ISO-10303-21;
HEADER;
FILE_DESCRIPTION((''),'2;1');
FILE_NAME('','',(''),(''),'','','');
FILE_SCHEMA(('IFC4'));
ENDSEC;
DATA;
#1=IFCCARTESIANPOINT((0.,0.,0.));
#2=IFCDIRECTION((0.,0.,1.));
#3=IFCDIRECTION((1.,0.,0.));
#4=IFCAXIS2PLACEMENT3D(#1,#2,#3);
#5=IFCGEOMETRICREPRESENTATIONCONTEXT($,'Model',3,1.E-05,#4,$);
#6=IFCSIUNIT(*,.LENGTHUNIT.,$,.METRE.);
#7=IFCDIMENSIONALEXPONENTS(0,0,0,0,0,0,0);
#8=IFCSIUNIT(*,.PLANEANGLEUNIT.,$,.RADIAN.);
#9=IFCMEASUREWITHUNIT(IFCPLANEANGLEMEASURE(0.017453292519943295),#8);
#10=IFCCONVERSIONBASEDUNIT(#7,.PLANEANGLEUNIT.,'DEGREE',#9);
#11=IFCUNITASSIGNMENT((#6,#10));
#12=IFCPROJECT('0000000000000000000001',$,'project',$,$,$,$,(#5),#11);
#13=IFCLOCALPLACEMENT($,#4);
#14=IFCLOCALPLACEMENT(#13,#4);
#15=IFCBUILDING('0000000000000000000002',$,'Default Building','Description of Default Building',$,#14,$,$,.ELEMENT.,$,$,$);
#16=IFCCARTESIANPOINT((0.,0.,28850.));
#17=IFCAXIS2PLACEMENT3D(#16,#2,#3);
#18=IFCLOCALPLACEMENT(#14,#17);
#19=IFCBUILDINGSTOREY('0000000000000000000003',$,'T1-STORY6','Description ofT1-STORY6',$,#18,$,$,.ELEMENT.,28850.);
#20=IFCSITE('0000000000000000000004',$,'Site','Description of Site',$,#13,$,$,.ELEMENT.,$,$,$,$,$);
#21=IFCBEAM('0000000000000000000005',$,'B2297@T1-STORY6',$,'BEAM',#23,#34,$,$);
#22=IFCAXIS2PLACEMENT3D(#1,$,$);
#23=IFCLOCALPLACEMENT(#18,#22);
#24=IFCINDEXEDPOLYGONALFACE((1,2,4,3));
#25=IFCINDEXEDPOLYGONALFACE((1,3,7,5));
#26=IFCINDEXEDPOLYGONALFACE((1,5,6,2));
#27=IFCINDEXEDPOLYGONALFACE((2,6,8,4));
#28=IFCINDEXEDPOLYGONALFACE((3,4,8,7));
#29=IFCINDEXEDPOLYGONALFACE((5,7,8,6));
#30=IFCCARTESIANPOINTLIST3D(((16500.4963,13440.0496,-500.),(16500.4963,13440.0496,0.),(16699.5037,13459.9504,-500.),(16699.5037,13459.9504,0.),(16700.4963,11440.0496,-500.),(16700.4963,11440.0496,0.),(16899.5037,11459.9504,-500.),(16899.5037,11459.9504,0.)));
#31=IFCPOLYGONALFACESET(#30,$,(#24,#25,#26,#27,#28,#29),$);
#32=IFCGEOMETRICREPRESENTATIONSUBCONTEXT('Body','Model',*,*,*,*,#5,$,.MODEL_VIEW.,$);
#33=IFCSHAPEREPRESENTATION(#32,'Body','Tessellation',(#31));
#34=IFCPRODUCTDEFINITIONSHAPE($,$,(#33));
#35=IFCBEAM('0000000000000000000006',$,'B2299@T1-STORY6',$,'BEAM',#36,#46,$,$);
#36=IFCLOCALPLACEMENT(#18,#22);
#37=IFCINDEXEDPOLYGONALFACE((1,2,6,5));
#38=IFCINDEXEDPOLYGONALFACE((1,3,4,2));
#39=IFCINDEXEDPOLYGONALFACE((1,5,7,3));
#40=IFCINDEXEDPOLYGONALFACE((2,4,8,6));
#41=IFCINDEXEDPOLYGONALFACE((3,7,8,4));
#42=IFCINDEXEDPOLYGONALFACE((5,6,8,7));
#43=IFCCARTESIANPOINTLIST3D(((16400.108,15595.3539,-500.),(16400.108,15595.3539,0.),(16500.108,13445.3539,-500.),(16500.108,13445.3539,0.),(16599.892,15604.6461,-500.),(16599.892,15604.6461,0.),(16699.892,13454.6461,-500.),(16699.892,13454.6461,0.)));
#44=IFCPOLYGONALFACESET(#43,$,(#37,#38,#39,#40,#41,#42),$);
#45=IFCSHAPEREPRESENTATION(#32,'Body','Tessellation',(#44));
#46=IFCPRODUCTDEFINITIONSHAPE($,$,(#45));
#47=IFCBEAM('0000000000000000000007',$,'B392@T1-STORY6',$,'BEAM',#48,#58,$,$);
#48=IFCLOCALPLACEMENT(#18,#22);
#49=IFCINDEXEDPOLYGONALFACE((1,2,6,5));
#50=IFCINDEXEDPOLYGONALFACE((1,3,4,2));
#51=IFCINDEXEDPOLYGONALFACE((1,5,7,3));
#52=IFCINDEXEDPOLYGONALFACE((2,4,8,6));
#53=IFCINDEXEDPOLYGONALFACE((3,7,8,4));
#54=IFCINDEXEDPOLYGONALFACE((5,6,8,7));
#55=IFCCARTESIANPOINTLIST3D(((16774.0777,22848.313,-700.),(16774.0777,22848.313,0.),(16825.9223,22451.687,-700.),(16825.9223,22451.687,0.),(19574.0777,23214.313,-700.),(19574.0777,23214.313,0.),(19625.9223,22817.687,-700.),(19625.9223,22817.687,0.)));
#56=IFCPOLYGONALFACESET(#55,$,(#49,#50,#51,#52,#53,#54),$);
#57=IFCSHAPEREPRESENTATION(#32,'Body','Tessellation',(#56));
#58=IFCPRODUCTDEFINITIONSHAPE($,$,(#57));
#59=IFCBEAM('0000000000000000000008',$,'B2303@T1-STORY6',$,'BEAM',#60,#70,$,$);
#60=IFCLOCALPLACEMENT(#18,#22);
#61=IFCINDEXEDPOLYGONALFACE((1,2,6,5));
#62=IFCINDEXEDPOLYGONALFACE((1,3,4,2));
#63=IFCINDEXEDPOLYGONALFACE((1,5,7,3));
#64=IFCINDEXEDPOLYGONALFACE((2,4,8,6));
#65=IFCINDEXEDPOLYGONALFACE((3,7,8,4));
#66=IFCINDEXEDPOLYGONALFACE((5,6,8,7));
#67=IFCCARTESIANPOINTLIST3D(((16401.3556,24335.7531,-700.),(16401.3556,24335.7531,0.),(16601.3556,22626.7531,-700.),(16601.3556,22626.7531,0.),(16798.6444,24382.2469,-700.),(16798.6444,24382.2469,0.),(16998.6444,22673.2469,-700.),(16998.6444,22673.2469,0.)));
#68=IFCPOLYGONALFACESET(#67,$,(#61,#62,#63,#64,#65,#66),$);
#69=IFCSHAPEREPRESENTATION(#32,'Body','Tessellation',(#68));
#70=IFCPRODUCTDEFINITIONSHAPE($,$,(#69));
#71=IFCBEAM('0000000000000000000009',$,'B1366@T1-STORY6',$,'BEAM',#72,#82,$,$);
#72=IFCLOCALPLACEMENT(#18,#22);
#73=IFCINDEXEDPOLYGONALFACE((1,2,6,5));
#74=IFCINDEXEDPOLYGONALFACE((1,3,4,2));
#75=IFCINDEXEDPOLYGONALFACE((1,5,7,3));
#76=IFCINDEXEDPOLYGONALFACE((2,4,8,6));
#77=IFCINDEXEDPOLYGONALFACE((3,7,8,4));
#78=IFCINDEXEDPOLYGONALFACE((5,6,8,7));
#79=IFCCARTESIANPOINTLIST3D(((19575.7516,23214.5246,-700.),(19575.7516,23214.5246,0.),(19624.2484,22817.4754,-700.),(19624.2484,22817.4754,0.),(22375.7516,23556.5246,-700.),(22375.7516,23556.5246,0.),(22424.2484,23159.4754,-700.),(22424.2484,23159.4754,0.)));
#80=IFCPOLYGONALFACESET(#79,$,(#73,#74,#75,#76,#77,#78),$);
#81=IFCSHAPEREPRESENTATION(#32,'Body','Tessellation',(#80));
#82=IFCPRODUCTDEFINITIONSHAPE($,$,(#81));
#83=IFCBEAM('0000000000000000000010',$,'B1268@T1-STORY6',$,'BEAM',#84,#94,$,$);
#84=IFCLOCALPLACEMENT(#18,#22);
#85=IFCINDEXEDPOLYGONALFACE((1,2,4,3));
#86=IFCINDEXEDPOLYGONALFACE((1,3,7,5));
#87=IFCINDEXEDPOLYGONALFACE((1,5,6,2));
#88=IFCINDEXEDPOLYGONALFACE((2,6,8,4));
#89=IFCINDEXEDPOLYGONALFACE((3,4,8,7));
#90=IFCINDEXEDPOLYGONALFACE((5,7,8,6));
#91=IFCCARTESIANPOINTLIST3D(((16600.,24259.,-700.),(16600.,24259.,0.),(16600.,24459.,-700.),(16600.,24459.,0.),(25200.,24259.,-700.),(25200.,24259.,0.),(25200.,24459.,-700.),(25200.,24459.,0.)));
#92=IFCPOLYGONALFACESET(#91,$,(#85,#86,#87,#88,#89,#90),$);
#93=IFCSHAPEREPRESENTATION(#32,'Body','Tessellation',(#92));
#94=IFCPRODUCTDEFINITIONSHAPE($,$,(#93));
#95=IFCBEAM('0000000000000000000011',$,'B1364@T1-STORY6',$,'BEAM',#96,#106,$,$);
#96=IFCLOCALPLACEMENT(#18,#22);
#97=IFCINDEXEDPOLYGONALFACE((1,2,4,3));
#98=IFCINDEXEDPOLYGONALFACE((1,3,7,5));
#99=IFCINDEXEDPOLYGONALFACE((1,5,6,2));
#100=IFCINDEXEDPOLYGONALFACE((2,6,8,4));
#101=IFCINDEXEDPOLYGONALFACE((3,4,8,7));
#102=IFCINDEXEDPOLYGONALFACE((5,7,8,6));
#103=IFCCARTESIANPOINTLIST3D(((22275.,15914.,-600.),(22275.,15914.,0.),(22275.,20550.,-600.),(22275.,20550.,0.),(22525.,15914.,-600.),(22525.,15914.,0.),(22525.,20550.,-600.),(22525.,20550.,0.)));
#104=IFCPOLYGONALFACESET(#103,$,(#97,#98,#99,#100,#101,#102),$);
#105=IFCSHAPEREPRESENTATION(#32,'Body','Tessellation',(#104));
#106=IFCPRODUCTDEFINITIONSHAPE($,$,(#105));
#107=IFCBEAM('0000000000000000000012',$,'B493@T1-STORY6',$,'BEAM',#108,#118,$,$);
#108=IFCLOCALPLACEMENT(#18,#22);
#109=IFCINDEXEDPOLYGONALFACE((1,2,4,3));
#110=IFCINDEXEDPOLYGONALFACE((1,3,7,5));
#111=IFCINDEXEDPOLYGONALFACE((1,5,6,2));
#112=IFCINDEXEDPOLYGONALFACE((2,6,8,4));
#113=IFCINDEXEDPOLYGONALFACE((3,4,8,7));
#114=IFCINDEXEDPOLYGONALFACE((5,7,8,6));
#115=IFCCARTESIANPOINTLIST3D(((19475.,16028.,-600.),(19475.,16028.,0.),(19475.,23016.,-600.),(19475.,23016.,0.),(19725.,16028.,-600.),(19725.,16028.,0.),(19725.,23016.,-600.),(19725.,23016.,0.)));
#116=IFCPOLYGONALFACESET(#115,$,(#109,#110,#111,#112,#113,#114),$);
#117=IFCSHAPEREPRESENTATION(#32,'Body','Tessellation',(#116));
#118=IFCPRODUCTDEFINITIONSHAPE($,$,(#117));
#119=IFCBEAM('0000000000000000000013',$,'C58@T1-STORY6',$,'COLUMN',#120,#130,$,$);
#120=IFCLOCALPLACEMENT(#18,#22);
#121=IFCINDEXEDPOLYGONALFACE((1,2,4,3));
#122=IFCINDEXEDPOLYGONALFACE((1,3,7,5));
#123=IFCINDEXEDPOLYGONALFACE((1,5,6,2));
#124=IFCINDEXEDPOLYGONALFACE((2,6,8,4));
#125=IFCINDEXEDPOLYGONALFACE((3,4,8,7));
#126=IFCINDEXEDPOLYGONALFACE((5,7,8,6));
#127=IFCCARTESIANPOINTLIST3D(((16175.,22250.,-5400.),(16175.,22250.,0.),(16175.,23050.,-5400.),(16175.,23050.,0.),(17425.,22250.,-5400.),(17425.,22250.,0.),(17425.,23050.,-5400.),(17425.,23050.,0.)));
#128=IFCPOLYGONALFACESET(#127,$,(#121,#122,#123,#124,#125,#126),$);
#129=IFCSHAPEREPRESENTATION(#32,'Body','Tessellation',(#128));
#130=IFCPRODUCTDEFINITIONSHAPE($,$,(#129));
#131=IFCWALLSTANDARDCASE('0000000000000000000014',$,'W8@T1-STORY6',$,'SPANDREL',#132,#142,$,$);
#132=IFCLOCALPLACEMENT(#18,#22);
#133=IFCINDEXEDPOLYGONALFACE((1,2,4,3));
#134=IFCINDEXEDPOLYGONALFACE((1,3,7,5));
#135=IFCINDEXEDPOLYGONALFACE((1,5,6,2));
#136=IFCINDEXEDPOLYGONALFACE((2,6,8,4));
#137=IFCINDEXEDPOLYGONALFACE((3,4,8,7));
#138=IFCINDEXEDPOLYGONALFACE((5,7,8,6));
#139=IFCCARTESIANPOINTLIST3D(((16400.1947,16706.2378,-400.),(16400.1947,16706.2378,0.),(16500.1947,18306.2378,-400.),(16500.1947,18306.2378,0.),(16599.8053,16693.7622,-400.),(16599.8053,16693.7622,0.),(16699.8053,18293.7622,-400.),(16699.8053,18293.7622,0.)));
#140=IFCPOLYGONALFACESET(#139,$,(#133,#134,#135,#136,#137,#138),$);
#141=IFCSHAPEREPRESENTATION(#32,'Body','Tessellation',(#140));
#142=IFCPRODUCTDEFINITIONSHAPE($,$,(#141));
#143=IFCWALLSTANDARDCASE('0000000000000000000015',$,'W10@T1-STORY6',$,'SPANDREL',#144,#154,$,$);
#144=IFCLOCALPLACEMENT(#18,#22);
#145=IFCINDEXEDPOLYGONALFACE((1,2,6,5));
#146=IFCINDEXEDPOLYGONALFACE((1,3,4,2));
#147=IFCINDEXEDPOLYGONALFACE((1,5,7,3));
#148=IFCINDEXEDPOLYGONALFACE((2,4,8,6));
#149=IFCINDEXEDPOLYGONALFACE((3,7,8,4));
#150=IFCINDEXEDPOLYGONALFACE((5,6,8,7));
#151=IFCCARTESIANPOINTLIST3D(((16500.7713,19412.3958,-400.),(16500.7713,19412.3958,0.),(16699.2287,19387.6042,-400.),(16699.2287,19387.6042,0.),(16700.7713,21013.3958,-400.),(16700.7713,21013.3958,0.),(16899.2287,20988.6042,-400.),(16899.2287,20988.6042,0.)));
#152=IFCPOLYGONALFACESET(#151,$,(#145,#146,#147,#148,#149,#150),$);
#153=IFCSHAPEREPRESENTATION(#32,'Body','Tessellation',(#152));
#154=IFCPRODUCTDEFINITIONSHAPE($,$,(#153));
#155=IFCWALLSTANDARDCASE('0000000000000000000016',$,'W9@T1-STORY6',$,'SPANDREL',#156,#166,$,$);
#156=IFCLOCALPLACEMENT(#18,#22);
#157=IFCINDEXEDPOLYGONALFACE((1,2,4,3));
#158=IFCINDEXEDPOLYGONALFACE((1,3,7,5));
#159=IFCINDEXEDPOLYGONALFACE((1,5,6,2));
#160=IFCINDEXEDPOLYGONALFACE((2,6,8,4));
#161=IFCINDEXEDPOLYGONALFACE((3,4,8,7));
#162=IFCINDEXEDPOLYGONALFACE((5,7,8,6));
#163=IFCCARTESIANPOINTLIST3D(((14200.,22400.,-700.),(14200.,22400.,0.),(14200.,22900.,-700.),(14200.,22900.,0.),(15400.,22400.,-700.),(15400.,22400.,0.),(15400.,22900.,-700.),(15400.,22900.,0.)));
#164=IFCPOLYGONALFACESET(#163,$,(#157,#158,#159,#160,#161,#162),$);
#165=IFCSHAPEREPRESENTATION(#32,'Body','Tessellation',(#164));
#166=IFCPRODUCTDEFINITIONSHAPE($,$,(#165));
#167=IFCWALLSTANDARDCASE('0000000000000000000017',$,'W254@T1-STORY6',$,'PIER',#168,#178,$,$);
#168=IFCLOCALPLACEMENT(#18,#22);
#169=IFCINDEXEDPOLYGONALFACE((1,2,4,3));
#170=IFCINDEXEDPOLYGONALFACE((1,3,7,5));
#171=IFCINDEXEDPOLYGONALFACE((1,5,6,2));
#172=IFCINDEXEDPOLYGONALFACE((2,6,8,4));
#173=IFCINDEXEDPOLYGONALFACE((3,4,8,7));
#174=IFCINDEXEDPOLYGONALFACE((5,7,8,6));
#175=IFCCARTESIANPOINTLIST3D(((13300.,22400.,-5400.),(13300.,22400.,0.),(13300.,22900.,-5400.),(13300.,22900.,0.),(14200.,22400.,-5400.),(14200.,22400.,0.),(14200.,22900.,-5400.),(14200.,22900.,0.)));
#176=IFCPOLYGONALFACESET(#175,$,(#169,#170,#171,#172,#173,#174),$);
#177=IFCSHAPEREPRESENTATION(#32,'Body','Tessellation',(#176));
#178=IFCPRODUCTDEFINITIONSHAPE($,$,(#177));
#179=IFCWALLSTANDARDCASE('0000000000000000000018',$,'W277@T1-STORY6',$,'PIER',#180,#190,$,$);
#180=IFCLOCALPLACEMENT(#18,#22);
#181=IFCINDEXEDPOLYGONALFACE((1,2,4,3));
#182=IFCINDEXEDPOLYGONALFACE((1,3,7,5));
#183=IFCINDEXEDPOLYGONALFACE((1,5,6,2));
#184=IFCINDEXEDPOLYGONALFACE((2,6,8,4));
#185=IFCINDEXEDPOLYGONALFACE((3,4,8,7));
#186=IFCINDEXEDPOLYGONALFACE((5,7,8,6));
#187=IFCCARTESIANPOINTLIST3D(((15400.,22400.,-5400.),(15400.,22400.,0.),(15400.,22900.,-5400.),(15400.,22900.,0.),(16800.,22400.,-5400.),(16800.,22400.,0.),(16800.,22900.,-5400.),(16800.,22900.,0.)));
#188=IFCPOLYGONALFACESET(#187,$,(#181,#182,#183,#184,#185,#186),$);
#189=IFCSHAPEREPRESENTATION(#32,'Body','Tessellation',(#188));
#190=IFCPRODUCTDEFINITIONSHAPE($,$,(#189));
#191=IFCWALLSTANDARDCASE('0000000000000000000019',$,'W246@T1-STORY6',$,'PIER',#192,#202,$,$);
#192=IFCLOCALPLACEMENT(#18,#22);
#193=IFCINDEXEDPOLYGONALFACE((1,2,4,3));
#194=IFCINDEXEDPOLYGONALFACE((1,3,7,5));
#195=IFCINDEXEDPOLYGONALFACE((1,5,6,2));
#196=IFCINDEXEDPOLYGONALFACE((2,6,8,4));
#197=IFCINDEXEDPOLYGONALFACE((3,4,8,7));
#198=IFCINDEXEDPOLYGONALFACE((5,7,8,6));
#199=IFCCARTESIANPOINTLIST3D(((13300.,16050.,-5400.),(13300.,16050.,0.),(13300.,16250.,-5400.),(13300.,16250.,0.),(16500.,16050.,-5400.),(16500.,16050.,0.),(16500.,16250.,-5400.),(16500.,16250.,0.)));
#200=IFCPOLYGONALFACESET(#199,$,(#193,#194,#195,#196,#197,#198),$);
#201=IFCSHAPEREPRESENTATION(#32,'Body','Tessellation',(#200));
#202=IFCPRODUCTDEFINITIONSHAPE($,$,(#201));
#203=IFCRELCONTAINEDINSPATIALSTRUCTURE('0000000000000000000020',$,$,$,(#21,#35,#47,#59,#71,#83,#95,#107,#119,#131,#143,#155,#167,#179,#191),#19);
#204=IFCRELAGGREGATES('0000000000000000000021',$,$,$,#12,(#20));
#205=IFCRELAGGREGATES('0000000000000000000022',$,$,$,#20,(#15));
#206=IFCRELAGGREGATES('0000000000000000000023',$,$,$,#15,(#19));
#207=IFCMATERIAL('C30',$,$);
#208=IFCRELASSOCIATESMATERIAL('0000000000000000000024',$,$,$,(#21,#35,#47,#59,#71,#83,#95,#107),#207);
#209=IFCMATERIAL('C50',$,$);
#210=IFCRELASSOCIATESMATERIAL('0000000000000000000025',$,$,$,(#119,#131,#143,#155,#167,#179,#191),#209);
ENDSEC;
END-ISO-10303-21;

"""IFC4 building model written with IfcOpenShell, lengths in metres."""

from ifc_helpers import new_model, entity, si_unit, converted_unit, frame, origin_with_axes, place, context, subcontext, project, spatial, indexed_curve, rectangle, outline, extrude, material, element, save


model = new_model("IFC4")

# Units and contexts
model_context = context("Model", 3, precision=1e-05, world=origin_with_axes())
body_context = subcontext(model_context, "Body", "Model", "MODEL_VIEW")
ifc_project = project(units=[si_unit("LENGTHUNIT", "METRE"), converted_unit("PLANEANGLEUNIT", "DEGREE", entity("IfcPlaneAngleMeasure", 0.017453292519943295), si_unit("PLANEANGLEUNIT", "RADIAN"), dimensions=[0, 0, 0, 0, 0, 0, 0])], contexts=[model_context])

# Site, building, storey
site_placement = place(None, origin_with_axes())
site = spatial("IfcSite", under=ifc_project, at=site_placement, Name="Site", Description="Description of Site", CompositionType="ELEMENT")
building_placement = place(site_placement, origin_with_axes())
building = spatial("IfcBuilding", under=site, at=building_placement, Name="Default Building", Description="Description of Default Building", CompositionType="ELEMENT")
storey_placement = place(building_placement, frame((0.0, 0.0, 28850.0), z_axis=(0.0, 0.0, 1.0), x_axis=(1.0, 0.0, 0.0)))
storey = spatial("IfcBuildingStorey", under=building, at=storey_placement, Name="T1-STORY6", Description="Description ofT1-STORY6", CompositionType="ELEMENT", Elevation=28850.0)

# Beams
ifc_material_1 = material(Name="C30")
beam_1_placement = place(storey_placement, frame((16600.0, 13450.0, -250.0), z_axis=(0.099504, -0.995037, 0.0), x_axis=(0.995037, 0.099504, 0.0)))
element("IfcBeam", 1, at=beam_1_placement, inside=storey, material=ifc_material_1, Name="B2297@T1-STORY6", ObjectType="BEAM", context=body_context, shape_type="SweptSolid", body=[
    extrude(rectangle(XDim=200.0, YDim=500.0), origin_with_axes(), (0.0, 0.0, 1.0), 2009.9751),
])
beam_2_placement = place(storey_placement, frame((16500.0, 15600.0, -250.0), z_axis=(0.046461, -0.99892, 0.0), x_axis=(0.99892, 0.046461, 0.0)))
element("IfcBeam", 2, at=beam_2_placement, inside=storey, material=ifc_material_1, Name="B2299@T1-STORY6", ObjectType="BEAM", context=body_context, shape_type="SweptSolid", body=[
    extrude(rectangle(XDim=200.0, YDim=500.0), origin_with_axes(), (0.0, 0.0, 1.0), 2152.3243),
])
beam_3_placement = place(storey_placement, frame((16800.0, 22650.0, -350.0), z_axis=(0.991565, 0.129612, 0.0), x_axis=(-0.129612, 0.991565, 0.0)))
element("IfcBeam", 3, at=beam_3_placement, inside=storey, material=ifc_material_1, Name="B392@T1-STORY6", ObjectType="BEAM", context=body_context, shape_type="SweptSolid", body=[
    extrude(rectangle(XDim=400.0, YDim=700.0), origin_with_axes(), (0.0, 0.0, 1.0), 2823.8194),
])
beam_4_placement = place(storey_placement, frame((16600.0, 24359.0, -350.0), z_axis=(0.116234, -0.993222, 0.0), x_axis=(0.993222, 0.116234, 0.0)))
element("IfcBeam", 4, at=beam_4_placement, inside=storey, material=ifc_material_1, Name="B2303@T1-STORY6", ObjectType="BEAM", context=body_context, shape_type="SweptSolid", body=[
    extrude(rectangle(XDim=400.0, YDim=700.0), origin_with_axes(), (0.0, 0.0, 1.0), 1720.663),
])
beam_5_placement = place(storey_placement, frame((19600.0, 23016.0, -350.0), z_axis=(0.992623, 0.121242, 0.0), x_axis=(-0.121242, 0.992623, 0.0)))
element("IfcBeam", 5, at=beam_5_placement, inside=storey, material=ifc_material_1, Name="B1366@T1-STORY6", ObjectType="BEAM", context=body_context, shape_type="SweptSolid", body=[
    extrude(rectangle(XDim=400.0, YDim=700.0), origin_with_axes(), (0.0, 0.0, 1.0), 2820.8091),
])
beam_6_placement = place(storey_placement, frame((16600.0, 24359.0, -350.0), z_axis=(1.0, 0.0, 0.0), x_axis=(0.0, 1.0, 0.0)))
element("IfcBeam", 6, at=beam_6_placement, inside=storey, material=ifc_material_1, Name="B1268@T1-STORY6", ObjectType="BEAM", context=body_context, shape_type="SweptSolid", body=[
    extrude(rectangle(XDim=200.0, YDim=700.0), origin_with_axes(), (0.0, 0.0, 1.0), 8600.0),
])
beam_7_placement = place(storey_placement, frame((22400.0, 15914.0, -300.0), z_axis=(0.0, 1.0, 0.0), x_axis=(-1.0, 0.0, 0.0)))
element("IfcBeam", 7, at=beam_7_placement, inside=storey, material=ifc_material_1, Name="B1364@T1-STORY6", ObjectType="BEAM", context=body_context, shape_type="SweptSolid", body=[
    extrude(rectangle(XDim=250.0, YDim=600.0), origin_with_axes(), (0.0, 0.0, 1.0), 4636.0),
])
beam_8_placement = place(storey_placement, frame((19600.0, 16028.0, -300.0), z_axis=(0.0, 1.0, 0.0), x_axis=(-1.0, 0.0, 0.0)))
element("IfcBeam", 8, at=beam_8_placement, inside=storey, material=ifc_material_1, Name="B493@T1-STORY6", ObjectType="BEAM", context=body_context, shape_type="SweptSolid", body=[
    extrude(rectangle(XDim=250.0, YDim=600.0), origin_with_axes(), (0.0, 0.0, 1.0), 6988.0),
])
ifc_material_2 = material(Name="C50")
beam_9_placement = place(storey_placement, frame((16800.0, 22650.0, -5400.0), z_axis=(0.0, 0.0, 1.0), x_axis=(0.0, -1.0, 0.0)))
element("IfcBeam", 9, at=beam_9_placement, inside=storey, material=ifc_material_2, Name="C58@T1-STORY6", ObjectType="COLUMN", context=body_context, shape_type="SweptSolid", body=[
    extrude(rectangle(XDim=800.0, YDim=1250.0), origin_with_axes(), (0.0, 0.0, 1.0), 5400.0),
])

# Walls
wall_1_placement = place(storey_placement, frame((16500.0, 16700.0, -400.0), z_axis=(0.0, 0.0, 1.0), x_axis=(0.062378, 0.998053, 0.0)))
element("IfcWallStandardCase", 10, at=wall_1_placement, inside=storey, material=ifc_material_2, Name="W8@T1-STORY6", ObjectType="SPANDREL", context=body_context, shape_type="SweptSolid", body=[
    extrude(outline(indexed_curve([(0.0, -100.0), (0.0, 100.0), (1603.122, 100.0), (1603.122, -100.0), (0.0, -100.0)], self_intersect=False)), origin_with_axes(), (0.0, 0.0, 1.0), 400.0),
])
wall_2_placement = place(storey_placement, frame((16600.0, 19400.0, -400.0), z_axis=(0.0, 0.0, 1.0), x_axis=(0.123958, 0.992287, 0.0)))
element("IfcWallStandardCase", 11, at=wall_2_placement, inside=storey, material=ifc_material_2, Name="W10@T1-STORY6", ObjectType="SPANDREL", context=body_context, shape_type="SweptSolid", body=[
    extrude(outline(indexed_curve([(0.0, -100.0), (0.0, 100.0), (1613.4438, 100.0), (1613.4438, -100.0), (0.0, -100.0)], self_intersect=False)), origin_with_axes(), (0.0, 0.0, 1.0), 400.0),
])
wall_3_placement = place(storey_placement, frame((14200.0, 22650.0, -700.0), z_axis=(0.0, 0.0, 1.0), x_axis=(1.0, 0.0, 0.0)))
element("IfcWallStandardCase", 12, at=wall_3_placement, inside=storey, material=ifc_material_2, Name="W9@T1-STORY6", ObjectType="SPANDREL", context=body_context, shape_type="SweptSolid", body=[
    extrude(outline(indexed_curve([(0.0, -250.0), (0.0, 250.0), (1200.0, 250.0), (1200.0, -250.0), (0.0, -250.0)], self_intersect=False)), origin_with_axes(), (0.0, 0.0, 1.0), 700.0),
])
wall_4_placement = place(storey_placement, frame((13300.0, 22650.0, -5400.0), z_axis=(0.0, 0.0, 1.0), x_axis=(1.0, 0.0, 0.0)))
element("IfcWallStandardCase", 13, at=wall_4_placement, inside=storey, material=ifc_material_2, Name="W254@T1-STORY6", ObjectType="PIER", context=body_context, shape_type="SweptSolid", body=[
    extrude(outline(indexed_curve([(0.0, -250.0), (0.0, 250.0), (900.0, 250.0), (900.0, -250.0), (0.0, -250.0)], self_intersect=False)), origin_with_axes(), (0.0, 0.0, 1.0), 5400.0),
])
wall_5_placement = place(storey_placement, frame((15400.0, 22650.0, -5400.0), z_axis=(0.0, 0.0, 1.0), x_axis=(1.0, 0.0, 0.0)))
element("IfcWallStandardCase", 14, at=wall_5_placement, inside=storey, material=ifc_material_2, Name="W277@T1-STORY6", ObjectType="PIER", context=body_context, shape_type="SweptSolid", body=[
    extrude(outline(indexed_curve([(0.0, -250.0), (0.0, 250.0), (1400.0, 250.0), (1400.0, -250.0), (0.0, -250.0)], self_intersect=False)), origin_with_axes(), (0.0, 0.0, 1.0), 5400.0),
])
wall_6_placement = place(storey_placement, frame((13300.0, 16150.0, -5400.0), z_axis=(0.0, 0.0, 1.0), x_axis=(1.0, 0.0, 0.0)))
element("IfcWallStandardCase", 15, at=wall_6_placement, inside=storey, material=ifc_material_2, Name="W246@T1-STORY6", ObjectType="PIER", context=body_context, shape_type="SweptSolid", body=[
    extrude(outline(indexed_curve([(0.0, -100.0), (0.0, 100.0), (3200.0, 100.0), (3200.0, -100.0), (0.0, -100.0)], self_intersect=False)), origin_with_axes(), (0.0, 0.0, 1.0), 5400.0),
])

save(model, "model.ifc")
